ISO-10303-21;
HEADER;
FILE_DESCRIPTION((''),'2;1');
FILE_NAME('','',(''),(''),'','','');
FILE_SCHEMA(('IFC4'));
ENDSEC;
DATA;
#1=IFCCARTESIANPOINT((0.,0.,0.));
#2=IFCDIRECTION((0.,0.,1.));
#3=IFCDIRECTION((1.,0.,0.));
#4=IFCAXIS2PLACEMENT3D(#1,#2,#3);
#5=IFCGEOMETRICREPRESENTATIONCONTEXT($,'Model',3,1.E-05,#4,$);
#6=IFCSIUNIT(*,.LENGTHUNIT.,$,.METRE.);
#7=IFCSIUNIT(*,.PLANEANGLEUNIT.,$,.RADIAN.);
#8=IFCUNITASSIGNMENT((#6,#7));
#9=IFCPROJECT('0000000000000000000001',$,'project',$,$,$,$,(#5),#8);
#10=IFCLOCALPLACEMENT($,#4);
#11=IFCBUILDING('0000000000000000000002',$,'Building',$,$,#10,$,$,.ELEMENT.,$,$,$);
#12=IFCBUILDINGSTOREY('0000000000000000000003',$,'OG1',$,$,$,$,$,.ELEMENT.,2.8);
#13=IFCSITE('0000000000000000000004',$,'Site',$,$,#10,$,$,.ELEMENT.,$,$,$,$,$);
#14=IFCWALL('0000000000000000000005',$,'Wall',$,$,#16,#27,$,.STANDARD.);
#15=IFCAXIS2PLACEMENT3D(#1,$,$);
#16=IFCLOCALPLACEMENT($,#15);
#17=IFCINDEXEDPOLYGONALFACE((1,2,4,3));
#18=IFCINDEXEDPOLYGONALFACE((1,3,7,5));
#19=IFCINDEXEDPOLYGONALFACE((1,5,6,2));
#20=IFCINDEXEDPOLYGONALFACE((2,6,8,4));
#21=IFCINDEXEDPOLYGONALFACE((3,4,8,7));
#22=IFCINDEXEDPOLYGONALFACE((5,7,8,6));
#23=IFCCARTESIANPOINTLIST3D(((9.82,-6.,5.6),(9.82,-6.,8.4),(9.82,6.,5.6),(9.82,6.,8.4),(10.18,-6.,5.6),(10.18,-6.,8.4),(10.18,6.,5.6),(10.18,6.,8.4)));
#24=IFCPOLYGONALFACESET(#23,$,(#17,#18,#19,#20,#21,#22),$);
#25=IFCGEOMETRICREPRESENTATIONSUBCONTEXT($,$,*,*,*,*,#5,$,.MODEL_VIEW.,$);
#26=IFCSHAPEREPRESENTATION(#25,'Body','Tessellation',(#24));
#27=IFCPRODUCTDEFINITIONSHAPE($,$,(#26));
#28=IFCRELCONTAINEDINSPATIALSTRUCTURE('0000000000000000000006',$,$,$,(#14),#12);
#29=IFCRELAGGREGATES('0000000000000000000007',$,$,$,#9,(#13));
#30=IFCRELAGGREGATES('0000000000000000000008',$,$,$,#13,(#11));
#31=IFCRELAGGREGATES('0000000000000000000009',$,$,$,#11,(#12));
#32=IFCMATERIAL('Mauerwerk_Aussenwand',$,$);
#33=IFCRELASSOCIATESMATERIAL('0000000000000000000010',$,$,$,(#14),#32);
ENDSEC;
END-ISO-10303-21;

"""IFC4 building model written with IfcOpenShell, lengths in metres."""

from ifc_helpers import new_model, si_unit, frame, frame_2d, origin, origin_with_axes, place, context, subcontext, project, spatial, rectangle, extrude, material, element, save


model = new_model("IFC4")

# Units and contexts
model_context = context("Model", 3, precision=1e-05, world=origin_with_axes())
sub_context = subcontext(model_context, None, None, "MODEL_VIEW")
ifc_project = project(units=[si_unit("LENGTHUNIT", "METRE"), si_unit("PLANEANGLEUNIT", "RADIAN")], contexts=[model_context])

# Site, building, storey
placement_1 = place(None, origin_with_axes())
site = spatial("IfcSite", under=ifc_project, at=placement_1, Name="Site", CompositionType="ELEMENT")
building = spatial("IfcBuilding", under=site, at=placement_1, Name="Building", CompositionType="ELEMENT")
storey = spatial("IfcBuildingStorey", under=building, Name="OG1", CompositionType="ELEMENT", Elevation=2.8)

# Wall
ifc_material = material(Name="Mauerwerk_Aussenwand")
placement_2 = place(None, origin_with_axes())
placement_3 = place(placement_2, frame((0.0, 0.0, 2.8)))
wall_placement = place(placement_3, frame((10.0, -6.0, 2.8), x_axis=(0.0, 1.0, 0.0)))
element("IfcWall", 1, at=wall_placement, inside=storey, material=ifc_material, Name="Wall", PredefinedType="STANDARD", context=sub_context, shape_type="SweptSolid", body=[
    extrude(rectangle(XDim=12.0, YDim=0.36, at=frame_2d((6.0, 0.0))), origin(), (0.0, 0.0, 1.0), 2.8),
])

save(model, "model.ifc")
